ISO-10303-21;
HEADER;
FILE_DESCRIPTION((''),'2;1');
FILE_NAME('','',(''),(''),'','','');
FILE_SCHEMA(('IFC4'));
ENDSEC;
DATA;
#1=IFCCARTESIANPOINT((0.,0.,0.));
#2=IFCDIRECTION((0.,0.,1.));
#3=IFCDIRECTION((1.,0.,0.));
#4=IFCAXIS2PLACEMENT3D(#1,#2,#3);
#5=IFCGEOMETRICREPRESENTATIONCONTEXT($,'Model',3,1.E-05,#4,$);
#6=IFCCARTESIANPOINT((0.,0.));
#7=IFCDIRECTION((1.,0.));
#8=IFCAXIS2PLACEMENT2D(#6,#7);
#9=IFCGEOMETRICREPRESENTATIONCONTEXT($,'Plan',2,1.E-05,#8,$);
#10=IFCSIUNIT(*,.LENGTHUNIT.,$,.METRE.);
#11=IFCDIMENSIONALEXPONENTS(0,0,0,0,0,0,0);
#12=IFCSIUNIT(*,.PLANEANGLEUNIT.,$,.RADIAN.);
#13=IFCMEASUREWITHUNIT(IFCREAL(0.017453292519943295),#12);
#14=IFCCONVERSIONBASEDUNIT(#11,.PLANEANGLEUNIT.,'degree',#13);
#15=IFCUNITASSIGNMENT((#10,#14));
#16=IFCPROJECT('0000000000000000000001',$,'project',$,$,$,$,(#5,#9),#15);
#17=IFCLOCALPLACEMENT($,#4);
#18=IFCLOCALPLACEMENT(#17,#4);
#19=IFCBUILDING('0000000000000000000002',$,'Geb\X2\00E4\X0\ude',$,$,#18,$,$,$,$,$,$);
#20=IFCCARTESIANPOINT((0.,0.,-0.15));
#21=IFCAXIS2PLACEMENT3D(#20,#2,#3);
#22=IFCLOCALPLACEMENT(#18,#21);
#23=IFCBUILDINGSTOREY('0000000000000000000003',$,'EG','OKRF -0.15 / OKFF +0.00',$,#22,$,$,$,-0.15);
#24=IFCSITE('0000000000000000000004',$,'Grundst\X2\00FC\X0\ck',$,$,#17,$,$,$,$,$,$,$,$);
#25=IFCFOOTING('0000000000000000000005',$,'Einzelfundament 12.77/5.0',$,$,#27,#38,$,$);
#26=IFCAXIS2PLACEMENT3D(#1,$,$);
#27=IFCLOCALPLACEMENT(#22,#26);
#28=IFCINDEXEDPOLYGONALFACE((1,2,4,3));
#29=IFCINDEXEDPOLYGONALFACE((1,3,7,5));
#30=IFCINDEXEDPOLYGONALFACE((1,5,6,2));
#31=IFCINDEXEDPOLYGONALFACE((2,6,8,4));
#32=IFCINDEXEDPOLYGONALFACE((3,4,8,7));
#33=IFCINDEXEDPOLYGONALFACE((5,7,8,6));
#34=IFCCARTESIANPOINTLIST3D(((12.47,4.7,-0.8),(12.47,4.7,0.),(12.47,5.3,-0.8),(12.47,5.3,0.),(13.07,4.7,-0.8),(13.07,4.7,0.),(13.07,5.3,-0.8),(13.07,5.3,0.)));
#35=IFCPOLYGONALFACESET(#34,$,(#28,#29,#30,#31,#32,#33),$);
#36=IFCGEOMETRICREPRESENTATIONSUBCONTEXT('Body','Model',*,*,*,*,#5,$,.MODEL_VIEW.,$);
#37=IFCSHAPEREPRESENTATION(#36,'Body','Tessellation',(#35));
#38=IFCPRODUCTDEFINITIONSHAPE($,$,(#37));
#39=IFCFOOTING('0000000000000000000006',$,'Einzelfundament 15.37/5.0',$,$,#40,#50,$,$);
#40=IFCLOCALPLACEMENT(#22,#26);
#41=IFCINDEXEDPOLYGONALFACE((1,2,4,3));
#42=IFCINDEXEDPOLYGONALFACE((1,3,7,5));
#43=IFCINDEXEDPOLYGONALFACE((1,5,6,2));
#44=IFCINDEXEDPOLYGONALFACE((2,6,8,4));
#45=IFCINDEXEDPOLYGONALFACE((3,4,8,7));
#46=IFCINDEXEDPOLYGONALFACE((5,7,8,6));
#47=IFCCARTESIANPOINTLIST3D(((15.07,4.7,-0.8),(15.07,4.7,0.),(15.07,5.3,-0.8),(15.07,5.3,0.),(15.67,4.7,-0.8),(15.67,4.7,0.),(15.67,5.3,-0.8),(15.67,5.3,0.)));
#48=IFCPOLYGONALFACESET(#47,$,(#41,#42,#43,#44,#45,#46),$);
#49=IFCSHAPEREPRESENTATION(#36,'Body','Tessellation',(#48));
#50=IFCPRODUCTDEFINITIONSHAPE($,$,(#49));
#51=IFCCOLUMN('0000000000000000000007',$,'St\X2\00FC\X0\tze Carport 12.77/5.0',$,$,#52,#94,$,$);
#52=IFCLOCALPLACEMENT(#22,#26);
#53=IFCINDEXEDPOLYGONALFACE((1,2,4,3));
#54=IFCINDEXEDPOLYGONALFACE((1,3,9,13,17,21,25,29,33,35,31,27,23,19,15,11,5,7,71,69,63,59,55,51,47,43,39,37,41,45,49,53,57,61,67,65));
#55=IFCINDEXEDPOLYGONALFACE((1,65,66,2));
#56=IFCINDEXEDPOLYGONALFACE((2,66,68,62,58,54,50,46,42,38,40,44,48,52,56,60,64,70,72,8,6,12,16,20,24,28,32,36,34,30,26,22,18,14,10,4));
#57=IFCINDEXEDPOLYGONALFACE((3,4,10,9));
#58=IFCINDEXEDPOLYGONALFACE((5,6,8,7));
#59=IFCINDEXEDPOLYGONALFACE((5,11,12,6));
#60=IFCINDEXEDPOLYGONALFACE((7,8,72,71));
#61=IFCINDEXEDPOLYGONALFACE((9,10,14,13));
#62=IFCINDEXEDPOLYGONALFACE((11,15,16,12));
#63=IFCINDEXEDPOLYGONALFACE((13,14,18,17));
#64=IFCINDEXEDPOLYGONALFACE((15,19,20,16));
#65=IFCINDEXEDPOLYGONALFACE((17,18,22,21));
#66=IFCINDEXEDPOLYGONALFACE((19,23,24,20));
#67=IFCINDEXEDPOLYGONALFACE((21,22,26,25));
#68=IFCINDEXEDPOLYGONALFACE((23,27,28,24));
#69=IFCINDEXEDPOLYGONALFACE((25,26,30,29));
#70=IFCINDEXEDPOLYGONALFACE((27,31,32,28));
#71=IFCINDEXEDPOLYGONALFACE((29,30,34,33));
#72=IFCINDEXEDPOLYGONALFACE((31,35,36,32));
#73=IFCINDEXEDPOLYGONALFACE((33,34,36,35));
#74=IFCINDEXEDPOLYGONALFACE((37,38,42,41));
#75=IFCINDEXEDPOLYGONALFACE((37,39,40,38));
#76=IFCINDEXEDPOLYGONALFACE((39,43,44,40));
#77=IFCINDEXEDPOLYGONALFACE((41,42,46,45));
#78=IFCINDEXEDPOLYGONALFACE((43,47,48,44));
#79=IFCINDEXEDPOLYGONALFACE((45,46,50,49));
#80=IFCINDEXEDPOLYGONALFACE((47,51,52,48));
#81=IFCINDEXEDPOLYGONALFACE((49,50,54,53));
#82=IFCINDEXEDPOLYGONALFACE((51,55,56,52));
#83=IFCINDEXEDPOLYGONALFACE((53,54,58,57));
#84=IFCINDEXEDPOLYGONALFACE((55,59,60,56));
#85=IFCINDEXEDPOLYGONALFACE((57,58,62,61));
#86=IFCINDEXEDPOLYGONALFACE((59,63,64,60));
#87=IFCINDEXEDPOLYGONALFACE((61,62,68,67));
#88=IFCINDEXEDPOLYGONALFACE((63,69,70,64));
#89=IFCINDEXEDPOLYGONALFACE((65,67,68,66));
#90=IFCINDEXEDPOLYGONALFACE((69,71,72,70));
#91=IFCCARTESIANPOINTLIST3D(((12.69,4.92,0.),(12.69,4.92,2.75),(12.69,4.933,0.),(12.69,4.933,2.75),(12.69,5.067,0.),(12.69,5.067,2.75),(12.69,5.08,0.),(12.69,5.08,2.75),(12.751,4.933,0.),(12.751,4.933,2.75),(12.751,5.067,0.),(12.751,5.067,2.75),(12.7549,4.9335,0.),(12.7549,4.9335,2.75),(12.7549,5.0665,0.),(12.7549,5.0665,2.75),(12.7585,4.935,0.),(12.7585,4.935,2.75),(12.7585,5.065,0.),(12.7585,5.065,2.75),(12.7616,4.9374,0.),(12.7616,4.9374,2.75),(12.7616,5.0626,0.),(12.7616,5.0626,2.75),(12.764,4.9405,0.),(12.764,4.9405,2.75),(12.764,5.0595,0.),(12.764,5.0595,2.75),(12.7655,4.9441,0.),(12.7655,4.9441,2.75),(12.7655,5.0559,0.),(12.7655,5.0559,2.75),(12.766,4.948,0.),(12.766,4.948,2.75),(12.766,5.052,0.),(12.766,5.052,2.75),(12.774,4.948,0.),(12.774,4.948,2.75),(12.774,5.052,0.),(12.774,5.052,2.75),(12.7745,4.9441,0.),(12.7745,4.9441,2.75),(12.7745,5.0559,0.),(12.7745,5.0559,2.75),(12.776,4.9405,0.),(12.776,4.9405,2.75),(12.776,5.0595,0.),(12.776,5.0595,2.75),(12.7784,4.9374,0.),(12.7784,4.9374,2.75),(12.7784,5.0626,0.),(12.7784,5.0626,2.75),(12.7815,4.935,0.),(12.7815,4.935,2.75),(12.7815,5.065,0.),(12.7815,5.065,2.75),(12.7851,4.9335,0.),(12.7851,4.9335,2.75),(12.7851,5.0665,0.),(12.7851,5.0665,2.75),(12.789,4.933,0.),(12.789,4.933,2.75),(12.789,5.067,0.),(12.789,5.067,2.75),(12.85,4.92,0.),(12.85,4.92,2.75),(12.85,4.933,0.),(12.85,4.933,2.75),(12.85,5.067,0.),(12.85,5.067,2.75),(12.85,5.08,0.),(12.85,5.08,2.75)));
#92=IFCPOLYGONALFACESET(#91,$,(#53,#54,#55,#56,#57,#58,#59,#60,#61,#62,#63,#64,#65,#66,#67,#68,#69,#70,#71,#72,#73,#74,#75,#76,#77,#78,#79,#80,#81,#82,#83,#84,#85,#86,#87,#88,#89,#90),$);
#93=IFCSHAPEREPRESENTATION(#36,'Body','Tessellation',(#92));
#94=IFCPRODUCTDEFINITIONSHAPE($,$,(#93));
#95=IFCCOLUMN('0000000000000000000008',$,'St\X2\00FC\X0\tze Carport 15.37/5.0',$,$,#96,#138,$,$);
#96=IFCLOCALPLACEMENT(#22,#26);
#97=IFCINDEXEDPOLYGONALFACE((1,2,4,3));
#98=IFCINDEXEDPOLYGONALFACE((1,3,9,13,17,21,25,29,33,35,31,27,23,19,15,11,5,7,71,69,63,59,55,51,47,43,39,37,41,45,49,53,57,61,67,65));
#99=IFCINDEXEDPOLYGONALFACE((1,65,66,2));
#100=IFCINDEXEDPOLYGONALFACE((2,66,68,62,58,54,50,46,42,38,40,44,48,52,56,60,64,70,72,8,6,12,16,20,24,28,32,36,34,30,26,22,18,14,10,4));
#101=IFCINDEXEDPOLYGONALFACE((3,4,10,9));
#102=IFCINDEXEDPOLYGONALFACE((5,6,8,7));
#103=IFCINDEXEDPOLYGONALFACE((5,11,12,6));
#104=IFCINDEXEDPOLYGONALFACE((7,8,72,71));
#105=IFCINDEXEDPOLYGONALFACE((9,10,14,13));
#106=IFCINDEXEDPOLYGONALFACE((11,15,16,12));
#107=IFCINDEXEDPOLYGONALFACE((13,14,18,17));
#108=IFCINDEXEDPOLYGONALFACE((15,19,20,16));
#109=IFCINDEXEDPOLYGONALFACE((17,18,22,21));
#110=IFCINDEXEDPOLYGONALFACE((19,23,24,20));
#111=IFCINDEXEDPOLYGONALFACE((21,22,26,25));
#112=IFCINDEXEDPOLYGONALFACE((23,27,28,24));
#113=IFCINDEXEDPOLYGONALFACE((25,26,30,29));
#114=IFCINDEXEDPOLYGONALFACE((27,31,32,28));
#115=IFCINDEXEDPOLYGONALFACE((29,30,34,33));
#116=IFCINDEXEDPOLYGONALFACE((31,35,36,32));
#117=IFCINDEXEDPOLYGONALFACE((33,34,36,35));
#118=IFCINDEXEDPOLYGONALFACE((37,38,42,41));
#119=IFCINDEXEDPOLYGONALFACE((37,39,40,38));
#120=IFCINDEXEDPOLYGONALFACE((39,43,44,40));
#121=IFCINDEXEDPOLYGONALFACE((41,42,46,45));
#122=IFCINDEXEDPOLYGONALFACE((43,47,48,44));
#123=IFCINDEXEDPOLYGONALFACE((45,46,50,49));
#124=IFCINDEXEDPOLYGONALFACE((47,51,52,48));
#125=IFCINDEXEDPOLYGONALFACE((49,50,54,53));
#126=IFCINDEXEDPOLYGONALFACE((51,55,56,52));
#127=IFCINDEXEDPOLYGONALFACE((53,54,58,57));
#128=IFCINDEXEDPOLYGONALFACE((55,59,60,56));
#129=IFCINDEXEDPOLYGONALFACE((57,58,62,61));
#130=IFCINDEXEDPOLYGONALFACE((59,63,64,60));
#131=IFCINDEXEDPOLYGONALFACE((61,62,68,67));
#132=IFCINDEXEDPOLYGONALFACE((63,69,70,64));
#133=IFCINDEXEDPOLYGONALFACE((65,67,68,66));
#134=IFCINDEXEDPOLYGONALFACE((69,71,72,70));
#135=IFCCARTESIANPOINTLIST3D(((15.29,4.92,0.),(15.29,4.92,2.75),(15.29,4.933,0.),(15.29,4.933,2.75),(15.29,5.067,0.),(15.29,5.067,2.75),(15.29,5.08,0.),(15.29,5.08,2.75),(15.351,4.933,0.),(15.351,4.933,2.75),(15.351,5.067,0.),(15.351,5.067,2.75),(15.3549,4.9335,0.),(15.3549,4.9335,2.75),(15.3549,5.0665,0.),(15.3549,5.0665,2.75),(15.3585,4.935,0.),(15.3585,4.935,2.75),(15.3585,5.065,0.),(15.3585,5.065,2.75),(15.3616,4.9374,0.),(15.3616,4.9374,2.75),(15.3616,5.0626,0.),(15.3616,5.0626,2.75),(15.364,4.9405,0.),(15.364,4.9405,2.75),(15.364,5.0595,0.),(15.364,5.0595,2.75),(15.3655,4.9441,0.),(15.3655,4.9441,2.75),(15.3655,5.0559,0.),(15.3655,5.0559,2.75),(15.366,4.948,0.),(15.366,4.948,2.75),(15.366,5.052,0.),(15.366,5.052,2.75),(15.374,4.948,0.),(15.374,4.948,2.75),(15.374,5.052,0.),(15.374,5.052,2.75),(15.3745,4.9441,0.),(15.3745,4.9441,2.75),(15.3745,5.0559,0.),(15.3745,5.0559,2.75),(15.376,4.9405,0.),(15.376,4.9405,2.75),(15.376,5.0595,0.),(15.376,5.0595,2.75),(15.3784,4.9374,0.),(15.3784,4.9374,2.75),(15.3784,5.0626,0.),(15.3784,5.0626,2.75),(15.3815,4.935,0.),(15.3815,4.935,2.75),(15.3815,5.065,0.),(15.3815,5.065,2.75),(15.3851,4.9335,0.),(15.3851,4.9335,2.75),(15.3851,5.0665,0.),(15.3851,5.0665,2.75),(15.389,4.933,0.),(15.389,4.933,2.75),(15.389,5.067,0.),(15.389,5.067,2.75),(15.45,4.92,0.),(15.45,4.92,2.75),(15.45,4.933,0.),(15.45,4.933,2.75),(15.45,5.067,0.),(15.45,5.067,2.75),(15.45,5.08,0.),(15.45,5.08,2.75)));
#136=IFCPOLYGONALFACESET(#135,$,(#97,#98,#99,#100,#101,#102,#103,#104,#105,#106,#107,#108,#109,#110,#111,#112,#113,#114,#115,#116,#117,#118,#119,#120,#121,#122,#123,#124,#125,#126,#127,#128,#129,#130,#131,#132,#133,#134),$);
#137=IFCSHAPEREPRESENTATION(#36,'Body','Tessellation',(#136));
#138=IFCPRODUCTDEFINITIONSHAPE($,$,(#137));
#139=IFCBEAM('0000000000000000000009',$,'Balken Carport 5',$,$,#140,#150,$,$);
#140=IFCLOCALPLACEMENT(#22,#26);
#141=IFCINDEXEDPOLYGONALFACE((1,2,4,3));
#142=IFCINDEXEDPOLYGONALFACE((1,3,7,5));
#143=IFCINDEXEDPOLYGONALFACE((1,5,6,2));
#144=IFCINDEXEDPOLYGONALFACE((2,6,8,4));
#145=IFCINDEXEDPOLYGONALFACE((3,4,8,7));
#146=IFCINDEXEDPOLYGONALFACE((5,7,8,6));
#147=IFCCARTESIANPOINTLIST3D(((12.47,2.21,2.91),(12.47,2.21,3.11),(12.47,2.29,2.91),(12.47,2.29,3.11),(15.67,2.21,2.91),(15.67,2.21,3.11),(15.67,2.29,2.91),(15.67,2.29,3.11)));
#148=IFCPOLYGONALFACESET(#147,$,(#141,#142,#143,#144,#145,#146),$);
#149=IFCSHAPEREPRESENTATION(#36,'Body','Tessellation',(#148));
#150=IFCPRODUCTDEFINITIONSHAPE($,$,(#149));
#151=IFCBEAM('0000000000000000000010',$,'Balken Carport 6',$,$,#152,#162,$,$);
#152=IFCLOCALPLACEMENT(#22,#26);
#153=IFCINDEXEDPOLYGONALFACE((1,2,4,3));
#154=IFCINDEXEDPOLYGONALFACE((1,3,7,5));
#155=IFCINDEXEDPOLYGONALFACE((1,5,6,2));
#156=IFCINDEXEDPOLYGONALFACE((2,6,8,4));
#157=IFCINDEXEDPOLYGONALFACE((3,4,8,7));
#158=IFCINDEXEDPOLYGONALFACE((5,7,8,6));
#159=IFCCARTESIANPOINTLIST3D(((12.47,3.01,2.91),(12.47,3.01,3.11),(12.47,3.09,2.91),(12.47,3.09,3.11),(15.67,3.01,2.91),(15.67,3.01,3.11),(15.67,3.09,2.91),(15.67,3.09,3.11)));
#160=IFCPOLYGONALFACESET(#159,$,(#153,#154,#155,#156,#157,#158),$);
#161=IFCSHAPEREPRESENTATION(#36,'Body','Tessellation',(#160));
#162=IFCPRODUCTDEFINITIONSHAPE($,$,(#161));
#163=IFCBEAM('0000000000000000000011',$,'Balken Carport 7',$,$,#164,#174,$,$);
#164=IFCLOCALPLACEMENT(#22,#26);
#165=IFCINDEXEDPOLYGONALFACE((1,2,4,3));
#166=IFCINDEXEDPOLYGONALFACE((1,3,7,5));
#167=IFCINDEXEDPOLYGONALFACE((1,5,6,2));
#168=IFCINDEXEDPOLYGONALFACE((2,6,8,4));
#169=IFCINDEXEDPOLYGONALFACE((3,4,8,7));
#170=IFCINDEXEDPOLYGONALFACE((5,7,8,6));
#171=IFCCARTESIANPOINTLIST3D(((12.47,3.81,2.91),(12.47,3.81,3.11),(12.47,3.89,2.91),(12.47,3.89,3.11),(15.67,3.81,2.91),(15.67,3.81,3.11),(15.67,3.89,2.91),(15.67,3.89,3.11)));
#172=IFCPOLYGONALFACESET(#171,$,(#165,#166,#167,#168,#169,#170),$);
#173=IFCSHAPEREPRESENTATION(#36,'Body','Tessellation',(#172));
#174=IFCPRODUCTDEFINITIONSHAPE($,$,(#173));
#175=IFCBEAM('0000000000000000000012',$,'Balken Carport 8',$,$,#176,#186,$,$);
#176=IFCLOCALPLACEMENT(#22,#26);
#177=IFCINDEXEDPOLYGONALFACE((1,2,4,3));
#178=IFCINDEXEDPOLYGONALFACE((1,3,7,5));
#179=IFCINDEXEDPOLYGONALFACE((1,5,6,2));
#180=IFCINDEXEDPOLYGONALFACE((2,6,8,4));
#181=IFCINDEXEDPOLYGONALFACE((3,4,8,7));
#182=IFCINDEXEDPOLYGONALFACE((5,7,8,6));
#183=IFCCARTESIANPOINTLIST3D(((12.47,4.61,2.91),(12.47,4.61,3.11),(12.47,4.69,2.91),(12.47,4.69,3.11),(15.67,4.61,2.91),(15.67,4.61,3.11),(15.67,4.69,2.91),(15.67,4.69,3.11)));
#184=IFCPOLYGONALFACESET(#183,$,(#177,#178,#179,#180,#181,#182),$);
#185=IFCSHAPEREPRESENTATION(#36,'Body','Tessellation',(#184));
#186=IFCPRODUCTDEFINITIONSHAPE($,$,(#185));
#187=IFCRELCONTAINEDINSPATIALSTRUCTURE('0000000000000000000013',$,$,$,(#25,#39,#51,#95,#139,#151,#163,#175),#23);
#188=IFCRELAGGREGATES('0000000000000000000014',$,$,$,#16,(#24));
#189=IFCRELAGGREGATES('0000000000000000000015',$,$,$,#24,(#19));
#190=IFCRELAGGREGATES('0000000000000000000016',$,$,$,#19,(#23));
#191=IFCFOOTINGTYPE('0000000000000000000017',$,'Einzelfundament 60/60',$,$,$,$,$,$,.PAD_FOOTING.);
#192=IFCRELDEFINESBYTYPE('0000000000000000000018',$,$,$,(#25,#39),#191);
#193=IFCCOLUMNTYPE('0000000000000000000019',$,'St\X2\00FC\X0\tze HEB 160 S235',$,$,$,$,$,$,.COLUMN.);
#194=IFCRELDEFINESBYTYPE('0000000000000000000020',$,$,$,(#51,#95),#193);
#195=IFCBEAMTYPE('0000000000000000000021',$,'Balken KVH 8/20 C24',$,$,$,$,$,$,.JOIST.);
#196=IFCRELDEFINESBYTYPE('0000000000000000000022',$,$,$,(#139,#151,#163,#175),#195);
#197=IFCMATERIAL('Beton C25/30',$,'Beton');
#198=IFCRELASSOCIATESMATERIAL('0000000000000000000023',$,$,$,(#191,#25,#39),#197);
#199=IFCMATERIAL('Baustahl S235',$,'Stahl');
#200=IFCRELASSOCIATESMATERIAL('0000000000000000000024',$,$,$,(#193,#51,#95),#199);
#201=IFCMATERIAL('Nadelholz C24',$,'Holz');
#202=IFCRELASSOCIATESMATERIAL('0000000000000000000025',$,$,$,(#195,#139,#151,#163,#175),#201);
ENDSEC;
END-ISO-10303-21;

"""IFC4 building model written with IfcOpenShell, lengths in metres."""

from ifc_helpers import new_model, entity, si_unit, converted_unit, frame, origin_with_axes, origin_2d_with_axis, place, context, subcontext, project, spatial, rectangle, i_section, extrude, material, material_profile, profile_set, profile_usage, type_object, element, save


model = new_model("IFC4")

# Units and contexts
model_context = context("Model", 3, precision=1e-05, world=origin_with_axes())
plan_context = context("Plan", 2, precision=1e-05, world=origin_2d_with_axis())
body_context = subcontext(model_context, "Body", "Model", "MODEL_VIEW")
ifc_project = project(units=[si_unit("LENGTHUNIT", "METRE"), converted_unit("PLANEANGLEUNIT", "degree", entity("IfcReal", 0.017453292519943295), si_unit("PLANEANGLEUNIT", "RADIAN"), dimensions=[0, 0, 0, 0, 0, 0, 0])], contexts=[model_context, plan_context])

# Site, building, storey
site_placement = place(None, origin_with_axes())
site = spatial("IfcSite", under=ifc_project, at=site_placement, Name="Grundstück")
building_placement = place(site_placement, origin_with_axes())
building = spatial("IfcBuilding", under=site, at=building_placement, Name="Gebäude")
storey_placement = place(building_placement, frame((0.0, 0.0, -0.15), z_axis=(0.0, 0.0, 1.0), x_axis=(1.0, 0.0, 0.0)))
storey = spatial("IfcBuildingStorey", under=building, at=storey_placement, Name="EG", Description="OKRF -0.15 / OKFF +0.00", Elevation=-0.15)

# Footings
ifc_material_1 = material(Name="Beton C25/30", Category="Beton")
ifc_material_profile_1 = material_profile(ifc_material_1, rectangle(XDim=0.6, YDim=0.6))
ifc_profile_set_1 = profile_set([ifc_material_profile_1], Name="Einzelfundament 60/60")
ifc_profile_usage_1 = profile_usage(ifc_profile_set_1)
footing_type = type_object("IfcFootingType", Name="Einzelfundament 60/60", PredefinedType="PAD_FOOTING", material=ifc_profile_set_1)
footing_1_placement = place(storey_placement, frame((12.77, 5.0, -0.8), z_axis=(0.0, 0.0, 1.0), x_axis=(1.0, 0.0, 0.0)))
element("IfcFooting", 1, at=footing_1_placement, inside=storey, type_object=footing_type, material=ifc_profile_usage_1, Name="Einzelfundament 12.77/5.0", context=body_context, shape_type="SweptSolid", body=[
    extrude(rectangle(XDim=0.6, YDim=0.6), origin_with_axes(), (0.0, 0.0, 1.0), 0.8),
])
ifc_profile_usage_2 = profile_usage(ifc_profile_set_1)
footing_2_placement = place(storey_placement, frame((15.37, 5.0, -0.8), z_axis=(0.0, 0.0, 1.0), x_axis=(1.0, 0.0, 0.0)))
element("IfcFooting", 2, at=footing_2_placement, inside=storey, type_object=footing_type, material=ifc_profile_usage_2, Name="Einzelfundament 15.37/5.0", context=body_context, shape_type="SweptSolid", body=[
    extrude(rectangle(XDim=0.6, YDim=0.6), origin_with_axes(), (0.0, 0.0, 1.0), 0.8),
])

# Columns
ifc_material_2 = material(Name="Baustahl S235", Category="Stahl")
ifc_material_profile_2 = material_profile(ifc_material_2, i_section(OverallWidth=0.16, OverallDepth=0.16, WebThickness=0.008, FlangeThickness=0.013, FilletRadius=0.015))
ifc_profile_set_2 = profile_set([ifc_material_profile_2], Name="Stütze HEB 160 S235")
ifc_profile_usage_3 = profile_usage(ifc_profile_set_2)
column_type = type_object("IfcColumnType", Name="Stütze HEB 160 S235", PredefinedType="COLUMN", material=ifc_profile_set_2)
column_1_placement = place(storey_placement, frame((12.77, 5.0, 0.0), z_axis=(0.0, 0.0, 1.0), x_axis=(1.0, 0.0, 0.0)))
element("IfcColumn", 3, at=column_1_placement, inside=storey, type_object=column_type, material=ifc_profile_usage_3, Name="Stütze Carport 12.77/5.0", context=body_context, shape_type="SweptSolid", body=[
    extrude(i_section(OverallWidth=0.16, OverallDepth=0.16, WebThickness=0.008, FlangeThickness=0.013, FilletRadius=0.015), origin_with_axes(), (0.0, 0.0, 1.0), 2.75),
])
ifc_profile_usage_4 = profile_usage(ifc_profile_set_2)
column_2_placement = place(storey_placement, frame((15.37, 5.0, 0.0), z_axis=(0.0, 0.0, 1.0), x_axis=(1.0, 0.0, 0.0)))
element("IfcColumn", 4, at=column_2_placement, inside=storey, type_object=column_type, material=ifc_profile_usage_4, Name="Stütze Carport 15.37/5.0", context=body_context, shape_type="SweptSolid", body=[
    extrude(i_section(OverallWidth=0.16, OverallDepth=0.16, WebThickness=0.008, FlangeThickness=0.013, FilletRadius=0.015), origin_with_axes(), (0.0, 0.0, 1.0), 2.75),
])

# Beams
ifc_material_3 = material(Name="Nadelholz C24", Category="Holz")
ifc_material_profile_3 = material_profile(ifc_material_3, rectangle(XDim=0.08, YDim=0.2))
ifc_profile_set_3 = profile_set([ifc_material_profile_3], Name="Balken KVH 8/20 C24")
ifc_profile_usage_5 = profile_usage(ifc_profile_set_3)
beam_type_1 = type_object("IfcBeamType", Name="Balken KVH 8/20 C24", PredefinedType="JOIST", material=ifc_profile_set_3)
beam_1_placement = place(storey_placement, frame((12.47, 2.25, 3.01), z_axis=(1.0, 0.0, 0.0), x_axis=(0.0, 1.0, 0.0)))
element("IfcBeam", 5, at=beam_1_placement, inside=storey, type_object=beam_type_1, material=ifc_profile_usage_5, Name="Balken Carport 5", context=body_context, shape_type="SweptSolid", body=[
    extrude(rectangle(XDim=0.08, YDim=0.2), origin_with_axes(), (0.0, 0.0, 1.0), 3.2),
])
ifc_profile_usage_6 = profile_usage(ifc_profile_set_3)
beam_2_placement = place(storey_placement, frame((12.47, 3.05, 3.01), z_axis=(1.0, 0.0, 0.0), x_axis=(0.0, 1.0, 0.0)))
element("IfcBeam", 6, at=beam_2_placement, inside=storey, type_object=beam_type_1, material=ifc_profile_usage_6, Name="Balken Carport 6", context=body_context, shape_type="SweptSolid", body=[
    extrude(rectangle(XDim=0.08, YDim=0.2), origin_with_axes(), (0.0, 0.0, 1.0), 3.2),
])
ifc_profile_usage_7 = profile_usage(ifc_profile_set_3)
beam_3_placement = place(storey_placement, frame((12.47, 3.85, 3.01), z_axis=(1.0, 0.0, 0.0), x_axis=(0.0, 1.0, 0.0)))
element("IfcBeam", 7, at=beam_3_placement, inside=storey, type_object=beam_type_1, material=ifc_profile_usage_7, Name="Balken Carport 7", context=body_context, shape_type="SweptSolid", body=[
    extrude(rectangle(XDim=0.08, YDim=0.2), origin_with_axes(), (0.0, 0.0, 1.0), 3.2),
])
ifc_profile_usage_8 = profile_usage(ifc_profile_set_3)
beam_4_placement = place(storey_placement, frame((12.47, 4.65, 3.01), z_axis=(1.0, 0.0, 0.0), x_axis=(0.0, 1.0, 0.0)))
element("IfcBeam", 8, at=beam_4_placement, inside=storey, type_object=beam_type_1, material=ifc_profile_usage_8, Name="Balken Carport 8", context=body_context, shape_type="SweptSolid", body=[
    extrude(rectangle(XDim=0.08, YDim=0.2), origin_with_axes(), (0.0, 0.0, 1.0), 3.2),
])

save(model, "model.ifc")
